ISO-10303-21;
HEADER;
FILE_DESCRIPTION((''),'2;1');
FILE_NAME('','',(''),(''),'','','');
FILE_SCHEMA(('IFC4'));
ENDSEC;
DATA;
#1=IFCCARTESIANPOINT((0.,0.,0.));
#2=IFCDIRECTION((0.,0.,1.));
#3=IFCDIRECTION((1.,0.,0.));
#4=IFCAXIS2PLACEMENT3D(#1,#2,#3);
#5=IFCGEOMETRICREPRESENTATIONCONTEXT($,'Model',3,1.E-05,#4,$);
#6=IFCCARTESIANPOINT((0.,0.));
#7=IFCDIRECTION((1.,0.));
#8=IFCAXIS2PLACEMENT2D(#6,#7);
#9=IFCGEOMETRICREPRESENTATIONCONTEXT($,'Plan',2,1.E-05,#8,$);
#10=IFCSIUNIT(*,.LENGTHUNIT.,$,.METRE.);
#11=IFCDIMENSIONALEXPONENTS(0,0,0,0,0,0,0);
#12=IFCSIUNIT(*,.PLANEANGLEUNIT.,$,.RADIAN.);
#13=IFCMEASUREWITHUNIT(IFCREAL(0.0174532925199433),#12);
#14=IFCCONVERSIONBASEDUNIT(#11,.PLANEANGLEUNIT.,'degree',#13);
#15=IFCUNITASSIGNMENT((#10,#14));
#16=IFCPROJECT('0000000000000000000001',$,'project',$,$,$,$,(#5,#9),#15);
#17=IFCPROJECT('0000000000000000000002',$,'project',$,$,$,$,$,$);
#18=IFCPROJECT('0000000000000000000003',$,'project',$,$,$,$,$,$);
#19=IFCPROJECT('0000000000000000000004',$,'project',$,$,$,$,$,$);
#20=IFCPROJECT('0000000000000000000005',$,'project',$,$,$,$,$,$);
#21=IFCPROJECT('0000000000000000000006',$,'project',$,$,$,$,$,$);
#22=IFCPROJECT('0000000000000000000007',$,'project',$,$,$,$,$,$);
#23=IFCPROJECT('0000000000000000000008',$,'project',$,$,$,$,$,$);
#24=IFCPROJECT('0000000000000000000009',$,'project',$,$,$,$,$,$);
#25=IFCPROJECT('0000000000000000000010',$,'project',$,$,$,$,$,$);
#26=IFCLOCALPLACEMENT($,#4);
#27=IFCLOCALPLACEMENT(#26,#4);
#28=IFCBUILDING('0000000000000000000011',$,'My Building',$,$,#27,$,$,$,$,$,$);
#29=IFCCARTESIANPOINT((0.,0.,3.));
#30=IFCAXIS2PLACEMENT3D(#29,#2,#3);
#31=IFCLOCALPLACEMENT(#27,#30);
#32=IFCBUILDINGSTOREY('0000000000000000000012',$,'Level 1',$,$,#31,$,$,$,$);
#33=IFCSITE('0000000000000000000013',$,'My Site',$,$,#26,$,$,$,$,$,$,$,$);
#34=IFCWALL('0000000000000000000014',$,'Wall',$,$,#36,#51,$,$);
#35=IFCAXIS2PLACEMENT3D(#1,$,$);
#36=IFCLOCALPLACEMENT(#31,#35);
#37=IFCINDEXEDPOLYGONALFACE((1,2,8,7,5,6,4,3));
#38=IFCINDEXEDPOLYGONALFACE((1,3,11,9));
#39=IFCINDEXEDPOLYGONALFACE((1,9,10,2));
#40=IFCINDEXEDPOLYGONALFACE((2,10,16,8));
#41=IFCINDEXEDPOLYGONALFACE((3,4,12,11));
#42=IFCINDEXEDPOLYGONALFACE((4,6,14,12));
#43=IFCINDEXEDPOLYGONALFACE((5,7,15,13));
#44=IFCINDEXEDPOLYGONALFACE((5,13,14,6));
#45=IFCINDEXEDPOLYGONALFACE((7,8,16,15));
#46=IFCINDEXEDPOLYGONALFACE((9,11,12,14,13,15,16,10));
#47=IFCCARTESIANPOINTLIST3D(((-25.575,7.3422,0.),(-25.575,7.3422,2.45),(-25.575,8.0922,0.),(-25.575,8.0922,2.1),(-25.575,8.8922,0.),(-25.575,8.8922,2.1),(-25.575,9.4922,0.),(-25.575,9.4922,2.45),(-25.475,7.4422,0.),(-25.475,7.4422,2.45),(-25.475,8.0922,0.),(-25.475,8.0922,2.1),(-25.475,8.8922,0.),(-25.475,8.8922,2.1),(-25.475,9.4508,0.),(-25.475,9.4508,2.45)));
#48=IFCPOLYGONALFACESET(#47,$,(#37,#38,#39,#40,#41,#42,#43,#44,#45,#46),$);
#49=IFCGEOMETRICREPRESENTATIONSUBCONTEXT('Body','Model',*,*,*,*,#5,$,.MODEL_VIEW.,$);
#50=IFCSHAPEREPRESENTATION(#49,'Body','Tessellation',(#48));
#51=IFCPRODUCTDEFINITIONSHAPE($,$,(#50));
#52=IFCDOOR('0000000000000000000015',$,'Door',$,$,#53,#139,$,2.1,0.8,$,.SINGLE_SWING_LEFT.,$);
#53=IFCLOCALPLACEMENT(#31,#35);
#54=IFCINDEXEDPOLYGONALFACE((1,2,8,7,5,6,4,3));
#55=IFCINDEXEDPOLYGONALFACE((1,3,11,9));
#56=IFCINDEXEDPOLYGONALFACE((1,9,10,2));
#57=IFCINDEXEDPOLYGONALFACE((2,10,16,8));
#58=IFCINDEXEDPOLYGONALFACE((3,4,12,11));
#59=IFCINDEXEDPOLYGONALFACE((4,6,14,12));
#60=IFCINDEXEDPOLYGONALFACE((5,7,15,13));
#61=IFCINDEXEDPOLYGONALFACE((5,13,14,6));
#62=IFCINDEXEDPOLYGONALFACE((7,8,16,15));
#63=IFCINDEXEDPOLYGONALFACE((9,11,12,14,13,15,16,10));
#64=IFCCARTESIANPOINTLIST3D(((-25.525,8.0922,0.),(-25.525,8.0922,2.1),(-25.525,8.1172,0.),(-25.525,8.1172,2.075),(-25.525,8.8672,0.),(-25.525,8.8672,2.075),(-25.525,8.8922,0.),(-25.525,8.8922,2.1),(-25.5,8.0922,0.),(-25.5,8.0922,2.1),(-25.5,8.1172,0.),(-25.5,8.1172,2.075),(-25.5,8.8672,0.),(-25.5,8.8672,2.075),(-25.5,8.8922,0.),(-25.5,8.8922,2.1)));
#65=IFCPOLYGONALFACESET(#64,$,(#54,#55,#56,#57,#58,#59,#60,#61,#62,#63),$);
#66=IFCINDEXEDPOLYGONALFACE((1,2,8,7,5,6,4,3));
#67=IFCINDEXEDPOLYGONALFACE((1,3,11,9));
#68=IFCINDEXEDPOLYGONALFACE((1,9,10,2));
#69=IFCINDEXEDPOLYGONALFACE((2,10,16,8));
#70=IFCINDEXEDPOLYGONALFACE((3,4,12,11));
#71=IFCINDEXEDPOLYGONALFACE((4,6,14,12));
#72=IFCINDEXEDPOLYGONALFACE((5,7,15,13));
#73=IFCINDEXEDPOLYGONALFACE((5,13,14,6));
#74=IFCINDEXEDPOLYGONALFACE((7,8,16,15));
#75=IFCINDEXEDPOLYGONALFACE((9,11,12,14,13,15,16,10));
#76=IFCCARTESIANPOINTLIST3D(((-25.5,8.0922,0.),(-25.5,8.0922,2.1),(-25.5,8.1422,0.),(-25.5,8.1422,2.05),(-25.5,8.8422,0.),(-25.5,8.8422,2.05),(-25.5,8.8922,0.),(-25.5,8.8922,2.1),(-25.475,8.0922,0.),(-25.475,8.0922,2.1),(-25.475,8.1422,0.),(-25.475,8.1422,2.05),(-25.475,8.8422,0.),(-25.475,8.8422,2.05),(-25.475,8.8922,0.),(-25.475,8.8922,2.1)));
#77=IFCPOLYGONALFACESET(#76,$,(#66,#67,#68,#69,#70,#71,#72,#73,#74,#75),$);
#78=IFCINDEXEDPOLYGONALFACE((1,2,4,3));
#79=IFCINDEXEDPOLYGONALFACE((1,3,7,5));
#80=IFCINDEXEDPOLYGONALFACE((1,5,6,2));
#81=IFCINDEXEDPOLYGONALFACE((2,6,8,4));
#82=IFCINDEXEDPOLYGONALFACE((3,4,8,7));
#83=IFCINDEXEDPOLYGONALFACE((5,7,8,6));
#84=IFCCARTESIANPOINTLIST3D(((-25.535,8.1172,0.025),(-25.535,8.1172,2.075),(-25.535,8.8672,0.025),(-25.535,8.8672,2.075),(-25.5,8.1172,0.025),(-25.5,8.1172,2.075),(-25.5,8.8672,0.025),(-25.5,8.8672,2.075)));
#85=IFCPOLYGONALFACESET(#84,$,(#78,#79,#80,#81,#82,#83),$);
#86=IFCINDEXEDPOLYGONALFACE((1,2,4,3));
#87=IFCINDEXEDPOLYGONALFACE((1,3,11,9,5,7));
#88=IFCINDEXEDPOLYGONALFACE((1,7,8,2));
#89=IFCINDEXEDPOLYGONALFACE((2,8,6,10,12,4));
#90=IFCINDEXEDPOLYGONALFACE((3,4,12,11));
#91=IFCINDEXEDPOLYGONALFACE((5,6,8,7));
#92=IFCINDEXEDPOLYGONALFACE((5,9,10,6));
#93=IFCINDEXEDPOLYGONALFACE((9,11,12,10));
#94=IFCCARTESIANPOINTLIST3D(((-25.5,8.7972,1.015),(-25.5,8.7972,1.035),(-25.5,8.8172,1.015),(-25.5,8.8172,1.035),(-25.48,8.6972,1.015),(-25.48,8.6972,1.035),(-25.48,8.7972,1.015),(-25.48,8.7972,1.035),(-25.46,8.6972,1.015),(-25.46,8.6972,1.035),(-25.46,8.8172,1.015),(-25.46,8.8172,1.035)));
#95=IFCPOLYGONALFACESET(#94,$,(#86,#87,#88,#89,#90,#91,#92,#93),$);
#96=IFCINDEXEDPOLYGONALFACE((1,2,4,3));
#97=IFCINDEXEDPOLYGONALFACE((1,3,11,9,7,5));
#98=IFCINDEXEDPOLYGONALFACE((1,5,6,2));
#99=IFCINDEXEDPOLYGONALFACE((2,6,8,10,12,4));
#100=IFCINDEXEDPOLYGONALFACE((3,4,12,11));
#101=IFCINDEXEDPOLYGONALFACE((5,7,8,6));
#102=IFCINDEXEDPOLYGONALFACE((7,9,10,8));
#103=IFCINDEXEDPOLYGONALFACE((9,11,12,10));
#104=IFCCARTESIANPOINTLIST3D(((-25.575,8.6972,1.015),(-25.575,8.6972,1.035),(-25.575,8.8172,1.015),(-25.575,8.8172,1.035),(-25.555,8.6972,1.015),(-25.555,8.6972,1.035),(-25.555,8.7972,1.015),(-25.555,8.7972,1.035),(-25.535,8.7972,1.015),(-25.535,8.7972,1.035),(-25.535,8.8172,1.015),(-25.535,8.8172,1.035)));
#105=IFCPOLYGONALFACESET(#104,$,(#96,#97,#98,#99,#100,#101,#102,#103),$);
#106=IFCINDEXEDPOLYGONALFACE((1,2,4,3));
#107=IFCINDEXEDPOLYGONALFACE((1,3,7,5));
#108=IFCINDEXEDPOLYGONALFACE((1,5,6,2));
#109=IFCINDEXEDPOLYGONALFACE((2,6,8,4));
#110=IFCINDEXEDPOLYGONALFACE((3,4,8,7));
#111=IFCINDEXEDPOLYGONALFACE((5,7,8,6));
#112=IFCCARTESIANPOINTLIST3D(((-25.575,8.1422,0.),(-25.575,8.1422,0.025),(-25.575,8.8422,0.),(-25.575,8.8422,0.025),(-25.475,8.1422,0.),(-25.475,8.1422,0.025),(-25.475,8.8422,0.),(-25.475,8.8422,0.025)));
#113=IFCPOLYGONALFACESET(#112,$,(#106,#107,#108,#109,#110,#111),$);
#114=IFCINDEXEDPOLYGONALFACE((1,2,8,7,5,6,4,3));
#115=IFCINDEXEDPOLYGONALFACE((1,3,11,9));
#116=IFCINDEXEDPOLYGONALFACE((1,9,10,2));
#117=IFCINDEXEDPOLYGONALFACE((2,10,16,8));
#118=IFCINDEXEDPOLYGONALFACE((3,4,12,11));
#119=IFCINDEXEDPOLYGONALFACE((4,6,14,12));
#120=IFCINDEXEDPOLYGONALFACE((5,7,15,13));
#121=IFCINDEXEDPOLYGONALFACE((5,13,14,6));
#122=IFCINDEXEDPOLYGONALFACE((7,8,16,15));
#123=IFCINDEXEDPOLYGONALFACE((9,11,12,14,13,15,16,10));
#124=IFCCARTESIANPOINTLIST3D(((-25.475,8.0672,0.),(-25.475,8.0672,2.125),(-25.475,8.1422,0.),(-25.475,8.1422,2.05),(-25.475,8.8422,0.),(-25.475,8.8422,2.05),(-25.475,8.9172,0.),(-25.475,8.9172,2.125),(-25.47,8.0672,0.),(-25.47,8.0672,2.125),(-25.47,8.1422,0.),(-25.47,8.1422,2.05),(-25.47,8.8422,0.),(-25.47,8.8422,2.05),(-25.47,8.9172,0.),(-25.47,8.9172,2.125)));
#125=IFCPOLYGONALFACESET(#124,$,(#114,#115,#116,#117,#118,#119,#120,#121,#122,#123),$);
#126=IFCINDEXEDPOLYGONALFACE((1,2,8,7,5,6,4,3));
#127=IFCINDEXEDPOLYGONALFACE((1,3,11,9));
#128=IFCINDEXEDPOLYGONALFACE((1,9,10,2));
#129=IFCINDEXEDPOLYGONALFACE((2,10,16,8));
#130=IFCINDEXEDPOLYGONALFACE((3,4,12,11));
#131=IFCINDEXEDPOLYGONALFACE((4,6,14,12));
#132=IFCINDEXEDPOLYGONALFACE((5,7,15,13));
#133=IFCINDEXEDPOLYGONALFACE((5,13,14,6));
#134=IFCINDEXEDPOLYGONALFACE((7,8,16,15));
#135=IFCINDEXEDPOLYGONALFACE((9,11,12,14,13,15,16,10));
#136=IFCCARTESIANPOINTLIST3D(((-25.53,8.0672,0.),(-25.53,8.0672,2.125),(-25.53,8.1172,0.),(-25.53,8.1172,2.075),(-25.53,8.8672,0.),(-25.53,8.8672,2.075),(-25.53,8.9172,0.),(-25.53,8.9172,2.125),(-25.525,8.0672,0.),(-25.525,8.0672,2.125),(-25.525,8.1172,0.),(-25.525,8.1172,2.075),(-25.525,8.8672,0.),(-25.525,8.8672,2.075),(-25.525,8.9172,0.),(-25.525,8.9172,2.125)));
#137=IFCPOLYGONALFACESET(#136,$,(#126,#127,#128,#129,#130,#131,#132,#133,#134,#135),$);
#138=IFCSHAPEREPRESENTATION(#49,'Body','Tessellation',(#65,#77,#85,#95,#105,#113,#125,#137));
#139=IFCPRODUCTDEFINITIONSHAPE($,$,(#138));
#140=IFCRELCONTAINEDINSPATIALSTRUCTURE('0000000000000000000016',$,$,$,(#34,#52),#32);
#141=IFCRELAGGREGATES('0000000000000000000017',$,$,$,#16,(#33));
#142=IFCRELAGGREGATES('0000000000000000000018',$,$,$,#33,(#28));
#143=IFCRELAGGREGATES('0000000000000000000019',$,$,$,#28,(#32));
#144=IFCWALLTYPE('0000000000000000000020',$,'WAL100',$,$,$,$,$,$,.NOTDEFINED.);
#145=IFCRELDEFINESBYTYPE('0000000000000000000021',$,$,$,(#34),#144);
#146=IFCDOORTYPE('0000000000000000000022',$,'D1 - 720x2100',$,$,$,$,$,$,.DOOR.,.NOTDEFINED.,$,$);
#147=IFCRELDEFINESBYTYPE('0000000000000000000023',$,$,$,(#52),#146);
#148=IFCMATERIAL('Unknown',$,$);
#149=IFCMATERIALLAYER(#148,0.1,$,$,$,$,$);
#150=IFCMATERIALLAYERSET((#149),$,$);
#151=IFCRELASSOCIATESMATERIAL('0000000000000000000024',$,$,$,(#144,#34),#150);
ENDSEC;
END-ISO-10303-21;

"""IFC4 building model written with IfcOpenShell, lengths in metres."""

from ifc_helpers import new_model, entity, si_unit, converted_unit, frame, origin_with_axes, origin_2d_with_axis, place, context, subcontext, project, spatial, line, indexed_curve, outline, extrude, clip, halfspace, shape, source, transform, mapped, material, layer, layer_set, layer_usage, type_object, type_shapes, element, fill, save


model = new_model("IFC4")

# Units and contexts
model_context = context("Model", 3, precision=1e-05, world=origin_with_axes())
plan_context = context("Plan", 2, precision=1e-05, world=origin_2d_with_axis())
body_context_1 = subcontext(model_context, "Body", "Model", "MODEL_VIEW")
body_context_2 = subcontext(plan_context, "Body", "Plan", "PLAN_VIEW")
ifc_project_1 = project(units=[si_unit("LENGTHUNIT", "METRE"), converted_unit("PLANEANGLEUNIT", "degree", entity("IfcReal", 0.0174532925199433), si_unit("PLANEANGLEUNIT", "RADIAN"), dimensions=[0, 0, 0, 0, 0, 0, 0])], contexts=[model_context, plan_context])
ifc_project_2 = project()
ifc_project_3 = project()
ifc_project_4 = project()
ifc_project_5 = project()
ifc_project_6 = project()
ifc_project_7 = project()
ifc_project_8 = project()
ifc_project_9 = project()
ifc_project_10 = project()

# Site, building, storey
site_placement = place(None, origin_with_axes())
site = spatial("IfcSite", under=ifc_project_1, at=site_placement, Name="My Site")
building_placement = place(site_placement, origin_with_axes())
building = spatial("IfcBuilding", under=site, at=building_placement, Name="My Building")
storey_placement = place(building_placement, frame((0.0, 0.0, 3.0), z_axis=(0.0, 0.0, 1.0), x_axis=(1.0, 0.0, 0.0)))
storey = spatial("IfcBuildingStorey", under=building, at=storey_placement, Name="Level 1")

# Shared definitions
ifc_material = material(Name="Unknown")

# Shared definitions
ifc_layer_1 = layer(ifc_material, 0.1)
ifc_layer_set_1 = layer_set([ifc_layer_1])
wall_type = type_object("IfcWallType", Name="WAL100", PredefinedType="NOTDEFINED", material=ifc_layer_set_1)

# Wall, opening, door
ifc_layer_usage_1 = layer_usage(ifc_layer_set_1, "AXIS2", "POSITIVE", 0.0)
wall_1_placement = place(storey_placement, frame((-25.475, 7.3422, 0.0), z_axis=(0.0, 0.0, 1.0), x_axis=(0.0, 1.0, 0.0)))
wall_1 = element("IfcWall", 1, at=wall_1_placement, inside=storey, type_object=wall_type, material=ifc_layer_usage_1, Name="Wall", context=body_context_1, shape_type="Clipping", body=[
    clip(clip(extrude(outline(indexed_curve([(0.0, 0.0), (0.0, 0.1), (2.25, 0.1), (2.25, 0.0), (0.0, 0.0)], self_intersect=False)), origin_with_axes(), (0.0, 0.0, 1.0), 2.45), halfspace(frame((2.1086, 0.0, -3.0), z_axis=(0.245001, -0.101484, 0.0), x_axis=(0.041422, 0.1, 0.0)), False)), halfspace(frame((0.1, 0.0, -3.0), z_axis=(-0.245001, -0.245, 0.0), x_axis=(-0.1, 0.1, 0.0)), False)),
])
shared_shape_1 = source(origin_with_axes(), body_context_1, "Body", "SweptSolid", [
    extrude(outline(indexed_curve([(0.0, 0.0), (0.8, 0.0), (0.8, 2.1), (0.0, 2.1)], segments=[line(1, 2, 2, 3, 3, 4, 4, 1)])), frame((0.0, -0.1, 0.0), z_axis=(0.0, -1.0, 0.0), x_axis=(1.0, 0.0, 0.0)), (0.0, 0.0, -1.0), 0.3),
])
opening_1_placement = place(wall_1_placement, frame((0.75, 0.0, 0.0), z_axis=(0.0, 0.0, 1.0), x_axis=(1.0, 0.0, 0.0)))
opening_1 = element("IfcOpeningElement", 2, at=opening_1_placement, cuts=wall_1, PredefinedType="OPENING", context=body_context_1, shape_type="MappedRepresentation", body=[
    mapped(shared_shape_1, transform((0.0, 0.0, 0.0), x_axis=(1.0, 0.0, 0.0), y_axis=(0.0, 1.0, 0.0), z_axis=(0.0, 0.0, 1.0), scale=1.0)),
])
door_type = type_object("IfcDoorType", Name="D1 - 720x2100", PredefinedType="DOOR")
shared_shape_2 = source(origin_with_axes(), body_context_1, "Body", "SweptSolid", [
    extrude(outline(indexed_curve([(0.0, 0.0), (0.0, 2.1), (0.8, 2.1), (0.8, 0.0), (0.775, 0.0), (0.775, 2.075), (0.025, 2.075), (0.025, 0.0)], segments=[line(1, 2, 2, 3, 3, 4, 4, 5, 5, 6, 6, 7, 7, 8, 8, 1)])), frame((0.0, 0.025, 0.0), z_axis=(0.0, -1.0, 0.0), x_axis=(1.0, 0.0, 0.0)), (0.0, 0.0, -1.0), 0.025),
    extrude(outline(indexed_curve([(0.0, 0.0), (0.0, 2.1), (0.8, 2.1), (0.8, 0.0), (0.75, 0.0), (0.75, 2.05), (0.05, 2.05), (0.05, 0.0)], segments=[line(1, 2, 2, 3, 3, 4, 4, 5, 5, 6, 6, 7, 7, 8, 8, 1)])), frame((0.0, 0.0, 0.0), z_axis=(0.0, -1.0, 0.0), x_axis=(1.0, 0.0, 0.0)), (0.0, 0.0, -1.0), 0.025),
    extrude(outline(indexed_curve([(0.0, 0.0), (0.75, 0.0), (0.75, 0.035), (0.0, 0.035)], segments=[line(1, 2, 2, 3, 3, 4, 4, 1)])), frame((0.025, 0.025, 0.025), z_axis=(0.0, 0.0, 1.0), x_axis=(1.0, 0.0, 0.0)), (0.0, 0.0, 1.0), 2.05),
    extrude(outline(indexed_curve([(0.0, 0.0), (0.0, -0.04), (-0.12, -0.04), (-0.12, -0.02), (-0.02, -0.02), (-0.02, 0.0)], segments=[line(1, 2, 2, 3, 3, 4, 4, 5, 5, 6, 6, 1)])), frame((0.725, 0.025, 1.015), z_axis=(0.0, 0.0, 1.0), x_axis=(1.0, 0.0, 0.0)), (0.0, 0.0, 1.0), 0.02),
    extrude(outline(indexed_curve([(0.0, 0.0), (0.0, 0.04), (-0.12, 0.04), (-0.12, 0.02), (-0.02, 0.02), (-0.02, 0.0)], segments=[line(1, 2, 2, 3, 3, 4, 4, 5, 5, 6, 6, 1)])), frame((0.725, 0.06, 1.015), z_axis=(0.0, 0.0, 1.0), x_axis=(1.0, 0.0, 0.0)), (0.0, 0.0, 1.0), 0.02),
    extrude(outline(indexed_curve([(0.0, 0.0), (0.7, 0.0), (0.7, 0.1), (0.0, 0.1)], segments=[line(1, 2, 2, 3, 3, 4, 4, 1)])), frame((0.05, 0.0, 0.0), z_axis=(0.0, 0.0, 1.0), x_axis=(1.0, 0.0, 0.0)), (0.0, 0.0, 1.0), 0.025),
    extrude(outline(indexed_curve([(0.0, 0.0), (0.0, 2.125), (0.85, 2.125), (0.85, 0.0), (0.775, 0.0), (0.775, 2.05), (0.075, 2.05), (0.075, 0.0)], segments=[line(1, 2, 2, 3, 3, 4, 4, 5, 5, 6, 6, 7, 7, 8, 8, 1)])), frame((-0.025, -0.005, 0.0), z_axis=(0.0, -1.0, 0.0), x_axis=(1.0, 0.0, 0.0)), (0.0, 0.0, -1.0), 0.005),
    extrude(outline(indexed_curve([(0.0, 0.0), (0.0, 2.125), (0.85, 2.125), (0.85, 0.0), (0.8, 0.0), (0.8, 2.075), (0.05, 2.075), (0.05, 0.0)], segments=[line(1, 2, 2, 3, 3, 4, 4, 5, 5, 6, 6, 7, 7, 8, 8, 1)])), frame((-0.025, 0.05, 0.0), z_axis=(0.0, -1.0, 0.0), x_axis=(1.0, 0.0, 0.0)), (0.0, 0.0, -1.0), 0.005),
])
shared_shape_3 = source(origin_with_axes(), body_context_2, "Body", "Curve2D", [
    entity("IfcIndexedPolyCurve", entity("IfcCartesianPointList2D", [[0.0, 0.0], [0.0, 0.05], [0.025, 0.05], [0.025, 0.025], [0.05, 0.025], [0.05, 0.0]]), [entity("IfcLineIndex", [1, 2, 2, 3, 3, 4, 4, 5, 5, 6, 6, 1])]),
    entity("IfcIndexedPolyCurve", entity("IfcCartesianPointList2D", [[0.8, 0.0], [0.8, 0.05], [0.775, 0.05], [0.775, 0.025], [0.75, 0.025], [0.75, 0.0]]), [entity("IfcLineIndex", [1, 2, 2, 3, 3, 4, 4, 5, 5, 6, 6, 1])]),
    entity("IfcTrimmedCurve", entity("IfcEllipse", entity("IfcAxis2Placement2D", entity("IfcCartesianPoint", [0.06, 0.05]), entity("IfcDirection", [1.0, 0.0])), 0.715, 0.75), [entity("IfcCartesianPoint", [0.775, 0.05])], [entity("IfcCartesianPoint", [0.06, 0.8])], True, "CARTESIAN"),
    entity("IfcIndexedPolyCurve", entity("IfcCartesianPointList2D", [[0.025, 0.05], [0.06, 0.05], [0.06, 0.8], [0.025, 0.8]]), [entity("IfcLineIndex", [1, 2, 2, 3, 3, 4, 4, 1])]),
])
type_shapes(door_type, [shared_shape_2, shared_shape_3])
door_placement = place(opening_1_placement, frame((0.0, 0.0, 0.0), z_axis=(0.0, 0.0, 1.0), x_axis=(1.0, 0.0, 0.0)))
door = element("IfcDoor", 3, at=door_placement, inside=storey, type_object=door_type, Name="Door", OperationType="SINGLE_SWING_LEFT", OverallHeight=2.1, OverallWidth=0.8, shapes=[
    shape(body_context_1, "Body", "MappedRepresentation", [mapped(shared_shape_2, transform((0.0, 0.0, 0.0), x_axis=(1.0, 0.0, 0.0), y_axis=(0.0, 1.0, 0.0), z_axis=(0.0, 0.0, 1.0), scale=1.0))]),
    shape(body_context_2, "Body", "MappedRepresentation", [mapped(shared_shape_3, transform((0.0, 0.0, 0.0), x_axis=(1.0, 0.0, 0.0), y_axis=(0.0, 1.0, 0.0), z_axis=(0.0, 0.0, 1.0), scale=1.0))]),
])
fill(opening_1, door)

save(model, "model.ifc")
